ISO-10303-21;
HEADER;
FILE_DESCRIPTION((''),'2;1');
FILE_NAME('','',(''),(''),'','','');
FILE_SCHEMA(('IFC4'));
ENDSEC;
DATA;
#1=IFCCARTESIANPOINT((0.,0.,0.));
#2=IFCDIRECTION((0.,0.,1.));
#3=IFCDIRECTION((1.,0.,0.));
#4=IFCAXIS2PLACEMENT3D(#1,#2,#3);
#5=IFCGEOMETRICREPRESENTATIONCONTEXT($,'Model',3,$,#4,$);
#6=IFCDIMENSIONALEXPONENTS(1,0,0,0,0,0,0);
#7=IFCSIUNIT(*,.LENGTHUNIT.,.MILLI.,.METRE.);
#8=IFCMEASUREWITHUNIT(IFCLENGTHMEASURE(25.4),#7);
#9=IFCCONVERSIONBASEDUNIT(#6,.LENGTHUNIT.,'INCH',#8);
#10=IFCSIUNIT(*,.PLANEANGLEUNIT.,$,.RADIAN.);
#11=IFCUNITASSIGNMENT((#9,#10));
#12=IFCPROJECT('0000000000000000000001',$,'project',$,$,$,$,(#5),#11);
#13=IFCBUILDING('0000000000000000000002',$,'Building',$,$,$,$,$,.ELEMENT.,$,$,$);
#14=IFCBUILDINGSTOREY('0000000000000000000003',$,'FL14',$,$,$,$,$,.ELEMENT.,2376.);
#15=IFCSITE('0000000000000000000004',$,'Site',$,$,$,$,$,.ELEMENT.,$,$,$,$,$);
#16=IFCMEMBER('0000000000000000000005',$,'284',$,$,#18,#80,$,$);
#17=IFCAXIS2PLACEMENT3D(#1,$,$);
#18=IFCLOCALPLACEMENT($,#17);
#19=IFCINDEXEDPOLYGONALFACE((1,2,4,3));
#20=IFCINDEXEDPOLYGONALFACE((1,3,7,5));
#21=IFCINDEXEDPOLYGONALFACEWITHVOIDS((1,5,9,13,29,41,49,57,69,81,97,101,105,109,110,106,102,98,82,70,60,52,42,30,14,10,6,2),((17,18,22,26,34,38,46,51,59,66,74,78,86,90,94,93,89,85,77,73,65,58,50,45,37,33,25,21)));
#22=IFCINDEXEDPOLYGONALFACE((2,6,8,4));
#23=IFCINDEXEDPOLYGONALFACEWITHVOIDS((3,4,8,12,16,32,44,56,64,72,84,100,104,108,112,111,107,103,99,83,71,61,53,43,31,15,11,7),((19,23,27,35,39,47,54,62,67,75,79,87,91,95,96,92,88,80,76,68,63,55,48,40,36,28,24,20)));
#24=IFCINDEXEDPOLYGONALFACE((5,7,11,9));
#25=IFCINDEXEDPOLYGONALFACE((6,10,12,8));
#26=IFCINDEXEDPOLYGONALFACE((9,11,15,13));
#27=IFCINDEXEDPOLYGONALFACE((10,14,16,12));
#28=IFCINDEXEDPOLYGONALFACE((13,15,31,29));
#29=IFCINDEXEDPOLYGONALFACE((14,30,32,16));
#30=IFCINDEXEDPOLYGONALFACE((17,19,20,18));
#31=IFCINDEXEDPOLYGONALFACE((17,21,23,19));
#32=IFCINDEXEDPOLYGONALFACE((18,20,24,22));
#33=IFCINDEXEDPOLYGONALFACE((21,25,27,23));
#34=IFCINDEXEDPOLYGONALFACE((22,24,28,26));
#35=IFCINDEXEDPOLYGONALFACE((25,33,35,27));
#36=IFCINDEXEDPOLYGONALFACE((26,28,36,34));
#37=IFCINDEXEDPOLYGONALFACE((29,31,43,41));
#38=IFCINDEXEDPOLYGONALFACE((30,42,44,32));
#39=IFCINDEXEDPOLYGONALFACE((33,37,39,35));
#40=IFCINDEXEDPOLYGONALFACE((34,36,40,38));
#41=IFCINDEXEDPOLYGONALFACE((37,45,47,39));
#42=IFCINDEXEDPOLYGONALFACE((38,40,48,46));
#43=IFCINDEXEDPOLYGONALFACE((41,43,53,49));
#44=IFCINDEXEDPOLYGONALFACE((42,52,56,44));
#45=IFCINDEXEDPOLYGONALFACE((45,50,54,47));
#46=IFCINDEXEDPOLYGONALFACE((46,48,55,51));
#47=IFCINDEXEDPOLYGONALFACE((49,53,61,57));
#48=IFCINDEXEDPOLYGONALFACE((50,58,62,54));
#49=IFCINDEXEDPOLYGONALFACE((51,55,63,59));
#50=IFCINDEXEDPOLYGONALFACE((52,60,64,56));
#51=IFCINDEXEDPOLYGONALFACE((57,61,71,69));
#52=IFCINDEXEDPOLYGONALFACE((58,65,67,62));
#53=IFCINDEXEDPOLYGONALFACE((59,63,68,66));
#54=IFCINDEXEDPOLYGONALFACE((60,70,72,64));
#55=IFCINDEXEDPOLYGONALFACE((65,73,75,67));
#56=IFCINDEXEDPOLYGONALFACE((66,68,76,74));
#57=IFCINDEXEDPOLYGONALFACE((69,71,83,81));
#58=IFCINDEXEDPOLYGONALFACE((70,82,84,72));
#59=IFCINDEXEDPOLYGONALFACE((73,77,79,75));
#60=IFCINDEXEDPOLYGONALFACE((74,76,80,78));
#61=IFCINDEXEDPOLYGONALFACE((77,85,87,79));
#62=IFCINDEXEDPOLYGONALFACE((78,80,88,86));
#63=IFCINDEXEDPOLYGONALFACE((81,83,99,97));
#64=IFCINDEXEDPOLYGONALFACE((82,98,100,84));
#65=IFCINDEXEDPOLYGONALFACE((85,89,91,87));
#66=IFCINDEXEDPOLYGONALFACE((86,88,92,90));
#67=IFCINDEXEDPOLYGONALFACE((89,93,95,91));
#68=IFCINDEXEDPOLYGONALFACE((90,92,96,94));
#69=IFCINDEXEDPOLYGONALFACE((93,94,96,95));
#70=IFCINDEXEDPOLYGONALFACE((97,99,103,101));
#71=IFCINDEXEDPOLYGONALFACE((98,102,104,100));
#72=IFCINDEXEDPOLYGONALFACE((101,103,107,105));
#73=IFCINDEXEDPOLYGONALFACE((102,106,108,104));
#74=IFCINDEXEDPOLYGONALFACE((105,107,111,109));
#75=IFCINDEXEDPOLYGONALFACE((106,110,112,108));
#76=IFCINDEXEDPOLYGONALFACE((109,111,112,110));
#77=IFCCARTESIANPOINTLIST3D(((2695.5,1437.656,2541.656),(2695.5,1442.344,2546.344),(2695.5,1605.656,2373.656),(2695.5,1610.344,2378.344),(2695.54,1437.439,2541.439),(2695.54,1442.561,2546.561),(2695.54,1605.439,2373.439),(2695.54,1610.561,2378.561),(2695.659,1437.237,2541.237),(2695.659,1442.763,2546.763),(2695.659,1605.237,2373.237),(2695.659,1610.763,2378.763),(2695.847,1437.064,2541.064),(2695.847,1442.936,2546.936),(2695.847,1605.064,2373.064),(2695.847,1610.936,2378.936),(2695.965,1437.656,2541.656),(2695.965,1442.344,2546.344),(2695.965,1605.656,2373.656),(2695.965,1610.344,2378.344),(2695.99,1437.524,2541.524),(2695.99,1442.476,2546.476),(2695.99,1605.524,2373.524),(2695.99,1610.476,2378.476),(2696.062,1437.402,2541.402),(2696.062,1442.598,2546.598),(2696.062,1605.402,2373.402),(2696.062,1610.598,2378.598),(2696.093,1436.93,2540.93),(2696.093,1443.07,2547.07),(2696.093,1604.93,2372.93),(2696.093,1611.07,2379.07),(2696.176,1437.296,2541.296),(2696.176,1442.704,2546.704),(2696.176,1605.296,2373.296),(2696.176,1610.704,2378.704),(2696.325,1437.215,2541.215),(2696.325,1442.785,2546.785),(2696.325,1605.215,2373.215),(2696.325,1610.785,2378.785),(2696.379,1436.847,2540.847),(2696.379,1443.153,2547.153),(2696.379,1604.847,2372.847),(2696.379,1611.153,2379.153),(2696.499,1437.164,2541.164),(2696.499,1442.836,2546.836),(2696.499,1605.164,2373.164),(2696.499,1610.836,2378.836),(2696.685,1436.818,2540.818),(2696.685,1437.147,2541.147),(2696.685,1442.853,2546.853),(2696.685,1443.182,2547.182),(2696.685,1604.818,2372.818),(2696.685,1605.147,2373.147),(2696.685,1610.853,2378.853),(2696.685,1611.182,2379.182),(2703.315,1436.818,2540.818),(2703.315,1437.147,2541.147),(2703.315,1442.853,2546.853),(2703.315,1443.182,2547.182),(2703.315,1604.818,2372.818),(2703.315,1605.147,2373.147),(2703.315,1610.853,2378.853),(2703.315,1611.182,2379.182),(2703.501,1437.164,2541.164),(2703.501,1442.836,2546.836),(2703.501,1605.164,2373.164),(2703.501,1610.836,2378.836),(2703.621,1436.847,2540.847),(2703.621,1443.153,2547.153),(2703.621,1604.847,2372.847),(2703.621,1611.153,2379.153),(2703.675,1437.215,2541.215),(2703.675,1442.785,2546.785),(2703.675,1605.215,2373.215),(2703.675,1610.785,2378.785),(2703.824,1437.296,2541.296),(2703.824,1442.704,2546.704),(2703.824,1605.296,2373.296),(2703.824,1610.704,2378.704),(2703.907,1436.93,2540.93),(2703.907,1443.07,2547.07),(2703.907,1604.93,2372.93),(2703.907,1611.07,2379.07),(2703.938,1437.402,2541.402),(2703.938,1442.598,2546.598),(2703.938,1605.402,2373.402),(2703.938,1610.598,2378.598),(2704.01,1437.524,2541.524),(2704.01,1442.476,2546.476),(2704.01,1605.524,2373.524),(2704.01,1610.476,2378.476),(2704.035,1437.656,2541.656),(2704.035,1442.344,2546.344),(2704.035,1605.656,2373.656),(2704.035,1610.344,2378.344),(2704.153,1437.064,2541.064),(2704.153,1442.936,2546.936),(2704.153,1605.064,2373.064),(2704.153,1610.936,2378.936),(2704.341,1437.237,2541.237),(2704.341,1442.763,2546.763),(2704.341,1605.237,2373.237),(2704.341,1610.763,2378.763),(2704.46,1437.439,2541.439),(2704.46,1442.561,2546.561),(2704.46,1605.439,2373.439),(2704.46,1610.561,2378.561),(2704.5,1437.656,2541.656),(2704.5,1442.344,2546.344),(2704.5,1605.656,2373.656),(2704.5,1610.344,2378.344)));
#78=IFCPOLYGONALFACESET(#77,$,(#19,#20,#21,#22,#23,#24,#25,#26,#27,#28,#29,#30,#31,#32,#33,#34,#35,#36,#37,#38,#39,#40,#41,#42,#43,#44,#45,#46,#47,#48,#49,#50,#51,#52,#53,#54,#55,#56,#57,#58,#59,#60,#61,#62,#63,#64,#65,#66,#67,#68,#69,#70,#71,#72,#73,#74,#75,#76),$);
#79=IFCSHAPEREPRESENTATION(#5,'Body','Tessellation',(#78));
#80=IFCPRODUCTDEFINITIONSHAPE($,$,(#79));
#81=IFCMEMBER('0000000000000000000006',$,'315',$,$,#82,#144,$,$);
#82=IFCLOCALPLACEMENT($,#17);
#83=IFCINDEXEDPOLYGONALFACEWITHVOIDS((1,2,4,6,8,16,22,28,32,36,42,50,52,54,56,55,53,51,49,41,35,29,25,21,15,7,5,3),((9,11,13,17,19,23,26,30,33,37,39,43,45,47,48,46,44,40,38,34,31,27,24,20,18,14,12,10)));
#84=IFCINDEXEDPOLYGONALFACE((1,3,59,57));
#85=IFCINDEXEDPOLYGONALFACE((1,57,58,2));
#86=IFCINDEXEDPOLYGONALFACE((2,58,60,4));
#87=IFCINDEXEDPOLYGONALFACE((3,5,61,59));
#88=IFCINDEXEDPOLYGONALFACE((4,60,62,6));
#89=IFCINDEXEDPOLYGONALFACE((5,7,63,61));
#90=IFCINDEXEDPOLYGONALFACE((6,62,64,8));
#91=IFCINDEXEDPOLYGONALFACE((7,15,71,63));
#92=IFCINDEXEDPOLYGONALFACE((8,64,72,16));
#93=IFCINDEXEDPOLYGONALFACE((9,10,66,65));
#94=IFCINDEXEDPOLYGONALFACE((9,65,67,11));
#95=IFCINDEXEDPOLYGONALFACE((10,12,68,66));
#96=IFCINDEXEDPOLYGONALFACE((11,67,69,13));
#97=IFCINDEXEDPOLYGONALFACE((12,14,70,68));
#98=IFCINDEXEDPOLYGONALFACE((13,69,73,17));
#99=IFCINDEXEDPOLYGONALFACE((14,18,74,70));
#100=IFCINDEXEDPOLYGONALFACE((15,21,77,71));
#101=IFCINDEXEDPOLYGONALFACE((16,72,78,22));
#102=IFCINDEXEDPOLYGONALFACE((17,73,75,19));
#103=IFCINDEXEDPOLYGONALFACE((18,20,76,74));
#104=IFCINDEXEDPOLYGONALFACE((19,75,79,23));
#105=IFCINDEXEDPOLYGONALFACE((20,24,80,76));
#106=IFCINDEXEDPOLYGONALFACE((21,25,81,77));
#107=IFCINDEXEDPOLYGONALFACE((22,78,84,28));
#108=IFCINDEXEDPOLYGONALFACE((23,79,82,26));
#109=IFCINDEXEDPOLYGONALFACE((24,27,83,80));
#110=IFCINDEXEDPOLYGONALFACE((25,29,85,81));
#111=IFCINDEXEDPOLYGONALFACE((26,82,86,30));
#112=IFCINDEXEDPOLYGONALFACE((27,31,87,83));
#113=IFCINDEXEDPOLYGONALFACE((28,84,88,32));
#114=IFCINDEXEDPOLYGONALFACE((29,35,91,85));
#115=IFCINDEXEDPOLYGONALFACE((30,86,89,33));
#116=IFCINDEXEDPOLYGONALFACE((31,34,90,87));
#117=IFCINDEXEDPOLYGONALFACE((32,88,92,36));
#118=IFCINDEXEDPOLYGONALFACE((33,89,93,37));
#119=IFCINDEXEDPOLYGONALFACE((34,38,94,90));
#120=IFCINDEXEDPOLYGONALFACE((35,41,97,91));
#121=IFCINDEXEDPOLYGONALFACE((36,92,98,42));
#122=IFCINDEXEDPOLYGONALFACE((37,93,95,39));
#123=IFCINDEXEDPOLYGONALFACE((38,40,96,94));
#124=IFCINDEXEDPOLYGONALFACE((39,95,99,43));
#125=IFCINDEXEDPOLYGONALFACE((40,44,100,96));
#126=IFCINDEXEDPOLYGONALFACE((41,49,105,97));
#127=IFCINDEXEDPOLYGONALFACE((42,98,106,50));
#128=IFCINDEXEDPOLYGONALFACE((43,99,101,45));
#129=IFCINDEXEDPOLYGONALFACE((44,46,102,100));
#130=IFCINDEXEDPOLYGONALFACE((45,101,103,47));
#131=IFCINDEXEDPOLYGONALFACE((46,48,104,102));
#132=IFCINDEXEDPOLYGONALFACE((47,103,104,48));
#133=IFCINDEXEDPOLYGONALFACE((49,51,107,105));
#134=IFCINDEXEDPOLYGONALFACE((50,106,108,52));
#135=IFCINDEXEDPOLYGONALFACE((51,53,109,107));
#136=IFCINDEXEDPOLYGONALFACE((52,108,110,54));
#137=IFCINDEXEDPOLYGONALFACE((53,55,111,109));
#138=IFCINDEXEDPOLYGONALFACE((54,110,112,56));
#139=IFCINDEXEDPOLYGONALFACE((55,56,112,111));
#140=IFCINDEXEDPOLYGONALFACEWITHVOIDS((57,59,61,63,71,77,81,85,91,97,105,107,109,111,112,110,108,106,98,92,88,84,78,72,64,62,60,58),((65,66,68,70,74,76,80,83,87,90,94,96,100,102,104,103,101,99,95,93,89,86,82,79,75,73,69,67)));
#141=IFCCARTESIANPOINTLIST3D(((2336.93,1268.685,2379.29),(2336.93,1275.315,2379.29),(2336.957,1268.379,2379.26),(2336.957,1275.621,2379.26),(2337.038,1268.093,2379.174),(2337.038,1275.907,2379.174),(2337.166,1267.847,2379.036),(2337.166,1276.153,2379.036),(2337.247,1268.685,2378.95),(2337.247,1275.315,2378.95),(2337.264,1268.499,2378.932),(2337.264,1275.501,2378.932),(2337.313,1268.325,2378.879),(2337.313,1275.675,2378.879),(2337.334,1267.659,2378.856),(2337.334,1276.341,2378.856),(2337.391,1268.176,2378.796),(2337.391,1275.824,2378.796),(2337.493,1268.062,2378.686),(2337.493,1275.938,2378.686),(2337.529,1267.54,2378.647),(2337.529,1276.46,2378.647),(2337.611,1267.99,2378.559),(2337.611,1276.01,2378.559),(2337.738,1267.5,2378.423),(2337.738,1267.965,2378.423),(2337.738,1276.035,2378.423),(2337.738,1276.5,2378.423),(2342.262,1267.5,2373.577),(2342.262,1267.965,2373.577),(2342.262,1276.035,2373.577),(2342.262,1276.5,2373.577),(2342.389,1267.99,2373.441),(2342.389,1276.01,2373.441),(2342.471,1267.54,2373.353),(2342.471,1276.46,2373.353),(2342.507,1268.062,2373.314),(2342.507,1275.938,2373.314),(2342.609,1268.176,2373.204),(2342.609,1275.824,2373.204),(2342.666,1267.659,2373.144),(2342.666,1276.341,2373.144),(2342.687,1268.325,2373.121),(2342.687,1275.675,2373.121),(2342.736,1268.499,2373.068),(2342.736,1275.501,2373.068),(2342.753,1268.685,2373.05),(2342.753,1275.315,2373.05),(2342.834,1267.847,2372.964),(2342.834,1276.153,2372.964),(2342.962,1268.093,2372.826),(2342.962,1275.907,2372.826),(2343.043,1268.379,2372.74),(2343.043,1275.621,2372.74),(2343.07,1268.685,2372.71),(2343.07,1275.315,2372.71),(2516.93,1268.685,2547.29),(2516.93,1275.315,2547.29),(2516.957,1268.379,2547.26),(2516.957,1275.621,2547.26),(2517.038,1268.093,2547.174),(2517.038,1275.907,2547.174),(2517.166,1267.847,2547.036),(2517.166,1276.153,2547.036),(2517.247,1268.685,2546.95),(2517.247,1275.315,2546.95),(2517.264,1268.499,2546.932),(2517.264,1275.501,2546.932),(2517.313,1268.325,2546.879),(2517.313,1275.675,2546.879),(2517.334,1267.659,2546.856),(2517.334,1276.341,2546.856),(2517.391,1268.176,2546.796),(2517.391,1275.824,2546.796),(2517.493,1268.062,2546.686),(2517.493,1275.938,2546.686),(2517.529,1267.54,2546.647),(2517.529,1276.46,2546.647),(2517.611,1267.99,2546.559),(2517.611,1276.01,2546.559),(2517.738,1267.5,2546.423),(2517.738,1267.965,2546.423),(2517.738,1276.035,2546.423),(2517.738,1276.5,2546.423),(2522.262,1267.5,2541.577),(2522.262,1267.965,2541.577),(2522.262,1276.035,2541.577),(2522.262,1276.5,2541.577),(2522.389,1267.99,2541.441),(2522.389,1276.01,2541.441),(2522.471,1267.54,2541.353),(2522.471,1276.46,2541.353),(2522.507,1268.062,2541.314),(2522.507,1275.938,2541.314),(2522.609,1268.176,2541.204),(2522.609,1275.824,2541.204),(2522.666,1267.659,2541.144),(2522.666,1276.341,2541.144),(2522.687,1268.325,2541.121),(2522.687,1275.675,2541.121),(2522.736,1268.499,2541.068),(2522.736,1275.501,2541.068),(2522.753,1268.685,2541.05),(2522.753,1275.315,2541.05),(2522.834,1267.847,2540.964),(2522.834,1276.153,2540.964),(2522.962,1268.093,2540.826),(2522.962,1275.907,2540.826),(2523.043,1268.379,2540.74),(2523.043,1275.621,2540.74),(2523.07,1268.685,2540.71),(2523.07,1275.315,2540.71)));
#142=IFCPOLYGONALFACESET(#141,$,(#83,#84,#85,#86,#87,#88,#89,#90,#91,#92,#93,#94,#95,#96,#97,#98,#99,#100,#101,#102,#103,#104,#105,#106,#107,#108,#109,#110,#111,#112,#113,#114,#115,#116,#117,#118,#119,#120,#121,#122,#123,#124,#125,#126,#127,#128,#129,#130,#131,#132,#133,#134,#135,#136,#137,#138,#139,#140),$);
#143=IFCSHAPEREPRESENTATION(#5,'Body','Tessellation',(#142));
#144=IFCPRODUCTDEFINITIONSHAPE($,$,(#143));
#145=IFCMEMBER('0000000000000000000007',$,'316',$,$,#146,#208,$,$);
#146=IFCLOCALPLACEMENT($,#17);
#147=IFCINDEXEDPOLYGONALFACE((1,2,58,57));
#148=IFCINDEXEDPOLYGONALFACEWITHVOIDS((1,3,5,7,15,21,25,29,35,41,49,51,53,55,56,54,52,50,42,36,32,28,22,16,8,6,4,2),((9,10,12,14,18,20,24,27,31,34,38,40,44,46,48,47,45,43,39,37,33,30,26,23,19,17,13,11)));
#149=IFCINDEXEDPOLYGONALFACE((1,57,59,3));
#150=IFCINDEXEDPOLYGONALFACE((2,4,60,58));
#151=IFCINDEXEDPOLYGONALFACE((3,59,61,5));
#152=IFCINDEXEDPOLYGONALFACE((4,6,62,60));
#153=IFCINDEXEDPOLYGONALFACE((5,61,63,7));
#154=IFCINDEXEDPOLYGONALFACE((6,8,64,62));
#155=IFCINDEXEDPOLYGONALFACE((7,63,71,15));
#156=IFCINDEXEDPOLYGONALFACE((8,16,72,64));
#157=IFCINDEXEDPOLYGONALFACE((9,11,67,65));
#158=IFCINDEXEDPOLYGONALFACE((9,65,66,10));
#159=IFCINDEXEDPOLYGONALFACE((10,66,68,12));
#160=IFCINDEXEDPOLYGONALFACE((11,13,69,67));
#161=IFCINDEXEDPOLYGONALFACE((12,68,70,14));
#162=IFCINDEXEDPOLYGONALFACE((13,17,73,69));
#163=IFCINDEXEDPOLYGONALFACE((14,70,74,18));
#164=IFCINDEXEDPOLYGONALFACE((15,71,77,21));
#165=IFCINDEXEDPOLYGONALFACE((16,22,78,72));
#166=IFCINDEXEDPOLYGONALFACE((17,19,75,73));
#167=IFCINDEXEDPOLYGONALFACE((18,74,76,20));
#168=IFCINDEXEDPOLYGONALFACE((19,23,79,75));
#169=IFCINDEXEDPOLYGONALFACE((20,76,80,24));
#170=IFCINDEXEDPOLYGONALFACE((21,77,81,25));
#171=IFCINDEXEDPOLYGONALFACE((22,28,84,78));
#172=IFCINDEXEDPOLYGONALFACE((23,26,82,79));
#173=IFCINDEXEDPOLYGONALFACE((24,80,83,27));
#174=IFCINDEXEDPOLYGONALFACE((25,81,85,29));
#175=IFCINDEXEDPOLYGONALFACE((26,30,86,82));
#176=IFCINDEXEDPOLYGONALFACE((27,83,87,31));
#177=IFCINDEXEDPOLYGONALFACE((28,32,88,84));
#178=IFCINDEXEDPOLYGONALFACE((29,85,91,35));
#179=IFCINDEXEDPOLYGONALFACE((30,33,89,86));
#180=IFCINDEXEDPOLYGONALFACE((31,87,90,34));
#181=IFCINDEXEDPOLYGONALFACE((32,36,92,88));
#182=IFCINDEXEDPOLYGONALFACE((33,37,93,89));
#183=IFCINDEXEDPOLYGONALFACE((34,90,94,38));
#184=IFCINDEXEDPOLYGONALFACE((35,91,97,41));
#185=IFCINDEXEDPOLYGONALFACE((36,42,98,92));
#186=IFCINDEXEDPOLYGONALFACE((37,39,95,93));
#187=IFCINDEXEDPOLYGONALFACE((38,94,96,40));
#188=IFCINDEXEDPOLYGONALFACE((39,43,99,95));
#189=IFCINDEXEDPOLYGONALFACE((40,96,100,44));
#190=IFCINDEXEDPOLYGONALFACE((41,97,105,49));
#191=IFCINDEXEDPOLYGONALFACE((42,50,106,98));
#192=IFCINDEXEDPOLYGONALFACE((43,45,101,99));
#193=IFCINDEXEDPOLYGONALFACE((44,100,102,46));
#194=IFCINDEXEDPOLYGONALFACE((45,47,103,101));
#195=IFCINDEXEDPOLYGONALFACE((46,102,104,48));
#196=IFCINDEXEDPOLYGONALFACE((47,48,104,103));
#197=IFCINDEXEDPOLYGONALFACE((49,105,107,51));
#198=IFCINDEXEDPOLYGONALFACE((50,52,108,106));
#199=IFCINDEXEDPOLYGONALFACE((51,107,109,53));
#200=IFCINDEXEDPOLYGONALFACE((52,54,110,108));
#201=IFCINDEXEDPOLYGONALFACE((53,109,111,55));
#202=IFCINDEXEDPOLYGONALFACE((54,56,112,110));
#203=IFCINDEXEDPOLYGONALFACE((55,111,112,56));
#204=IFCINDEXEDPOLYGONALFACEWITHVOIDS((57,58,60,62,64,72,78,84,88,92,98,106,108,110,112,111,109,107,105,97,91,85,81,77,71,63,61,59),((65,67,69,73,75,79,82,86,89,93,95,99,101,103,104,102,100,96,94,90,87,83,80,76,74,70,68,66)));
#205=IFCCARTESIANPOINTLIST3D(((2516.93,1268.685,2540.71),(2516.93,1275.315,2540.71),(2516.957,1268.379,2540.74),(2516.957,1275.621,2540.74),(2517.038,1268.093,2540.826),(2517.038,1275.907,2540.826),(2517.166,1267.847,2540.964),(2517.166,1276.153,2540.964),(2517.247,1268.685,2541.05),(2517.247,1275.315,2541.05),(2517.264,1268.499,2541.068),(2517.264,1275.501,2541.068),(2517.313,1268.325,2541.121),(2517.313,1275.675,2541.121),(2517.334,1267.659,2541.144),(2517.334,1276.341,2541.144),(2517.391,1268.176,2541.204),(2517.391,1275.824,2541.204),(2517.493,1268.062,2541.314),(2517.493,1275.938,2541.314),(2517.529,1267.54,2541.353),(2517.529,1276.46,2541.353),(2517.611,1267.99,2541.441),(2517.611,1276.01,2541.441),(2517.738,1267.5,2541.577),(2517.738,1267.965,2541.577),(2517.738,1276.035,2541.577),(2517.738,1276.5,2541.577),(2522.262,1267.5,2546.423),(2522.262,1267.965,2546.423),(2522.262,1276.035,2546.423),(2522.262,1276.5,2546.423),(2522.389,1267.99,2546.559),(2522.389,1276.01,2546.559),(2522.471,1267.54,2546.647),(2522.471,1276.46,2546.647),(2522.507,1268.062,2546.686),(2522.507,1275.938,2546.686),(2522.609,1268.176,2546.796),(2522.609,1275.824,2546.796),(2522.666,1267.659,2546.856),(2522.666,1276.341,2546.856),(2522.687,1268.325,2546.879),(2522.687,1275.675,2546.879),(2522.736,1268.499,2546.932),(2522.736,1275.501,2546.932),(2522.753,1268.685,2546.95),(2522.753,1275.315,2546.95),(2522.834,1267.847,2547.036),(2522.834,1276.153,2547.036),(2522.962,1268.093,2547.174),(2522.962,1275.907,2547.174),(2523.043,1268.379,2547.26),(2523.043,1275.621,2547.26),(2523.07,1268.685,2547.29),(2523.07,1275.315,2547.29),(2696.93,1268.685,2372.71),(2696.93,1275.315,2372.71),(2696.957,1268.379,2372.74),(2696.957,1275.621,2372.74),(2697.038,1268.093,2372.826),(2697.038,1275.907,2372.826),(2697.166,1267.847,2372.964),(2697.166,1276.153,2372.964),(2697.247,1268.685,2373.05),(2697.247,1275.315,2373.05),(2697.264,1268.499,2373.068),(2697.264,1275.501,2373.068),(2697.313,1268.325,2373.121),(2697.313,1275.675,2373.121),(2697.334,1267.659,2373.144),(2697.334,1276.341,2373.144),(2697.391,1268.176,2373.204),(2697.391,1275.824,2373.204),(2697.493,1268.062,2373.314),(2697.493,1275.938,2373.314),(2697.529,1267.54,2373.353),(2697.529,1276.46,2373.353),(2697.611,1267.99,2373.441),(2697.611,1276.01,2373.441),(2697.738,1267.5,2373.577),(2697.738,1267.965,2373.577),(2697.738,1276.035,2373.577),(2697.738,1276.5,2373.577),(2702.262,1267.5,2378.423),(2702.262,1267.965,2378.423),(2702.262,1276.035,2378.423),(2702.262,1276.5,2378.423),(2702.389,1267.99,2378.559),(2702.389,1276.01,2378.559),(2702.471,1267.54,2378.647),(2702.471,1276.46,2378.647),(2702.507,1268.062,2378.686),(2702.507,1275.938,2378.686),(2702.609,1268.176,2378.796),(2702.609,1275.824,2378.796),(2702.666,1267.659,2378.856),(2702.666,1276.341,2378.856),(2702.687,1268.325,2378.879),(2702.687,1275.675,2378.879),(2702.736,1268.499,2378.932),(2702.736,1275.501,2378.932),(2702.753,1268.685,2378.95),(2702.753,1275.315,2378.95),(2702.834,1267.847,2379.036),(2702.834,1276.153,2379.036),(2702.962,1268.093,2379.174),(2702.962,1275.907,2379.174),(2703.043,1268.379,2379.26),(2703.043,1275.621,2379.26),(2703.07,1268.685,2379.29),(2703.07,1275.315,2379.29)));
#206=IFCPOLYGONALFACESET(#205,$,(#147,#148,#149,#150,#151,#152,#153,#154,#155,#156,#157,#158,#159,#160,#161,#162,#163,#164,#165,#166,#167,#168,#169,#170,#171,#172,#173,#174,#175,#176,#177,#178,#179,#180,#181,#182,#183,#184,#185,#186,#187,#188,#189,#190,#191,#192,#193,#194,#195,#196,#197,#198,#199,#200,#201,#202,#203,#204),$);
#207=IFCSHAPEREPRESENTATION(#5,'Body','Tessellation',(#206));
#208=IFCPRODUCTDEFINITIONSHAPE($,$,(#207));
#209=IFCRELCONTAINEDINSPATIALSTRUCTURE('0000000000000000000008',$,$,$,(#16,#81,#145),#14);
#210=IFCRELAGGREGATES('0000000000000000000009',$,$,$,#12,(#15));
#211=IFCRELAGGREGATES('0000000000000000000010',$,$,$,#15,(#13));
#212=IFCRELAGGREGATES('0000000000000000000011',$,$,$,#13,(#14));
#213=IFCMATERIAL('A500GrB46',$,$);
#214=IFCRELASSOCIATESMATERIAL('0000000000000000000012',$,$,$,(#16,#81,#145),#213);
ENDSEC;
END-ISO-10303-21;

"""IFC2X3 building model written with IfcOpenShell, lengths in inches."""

from ifc_helpers import new_model, entity, si_unit, converted_unit, frame, origin_with_axes, origin_2d_with_axis, place, context, project, spatial, hollow_rectangle, extrude, material, element, save


model = new_model("IFC2X3")

# Units and contexts
model_context = context("Model", 3, world=origin_with_axes())
ifc_project = project(units=[converted_unit("LENGTHUNIT", "INCH", entity("IfcLengthMeasure", 25.4), si_unit("LENGTHUNIT", "METRE", prefix="MILLI"), dimensions=[1, 0, 0, 0, 0, 0, 0]), si_unit("PLANEANGLEUNIT", "RADIAN")], contexts=[model_context])

# Site, building, storey
site = spatial("IfcSite", under=ifc_project, Name="Site", CompositionType="ELEMENT")
building = spatial("IfcBuilding", under=site, Name="Building", CompositionType="ELEMENT")
storey = spatial("IfcBuildingStorey", under=building, Name="FL14", CompositionType="ELEMENT", Elevation=2376.0)

# Members
ifc_material_1 = material(Name="A500GrB46")
for number, where, z_axis, x_axis, name in (
    (1, (2700.0, 1608.0, 2376.0), (0.0, -0.707107, 0.707107), (1.0, 0.0, 0.0), "284"),
):
    element("IfcMember", number, at=place(None, frame(where, z_axis=z_axis, x_axis=x_axis)), inside=storey, material=ifc_material_1, Name=name, context=model_context, shape_type="SweptSolid", body=[
        extrude(hollow_rectangle(XDim=9.0, YDim=9.0, WallThickness=0.465, InnerFilletRadius=0.72, OuterFilletRadius=1.185, at=origin_2d_with_axis()), origin_with_axes(), (0.0, 0.0, 1.0), 237.588),
    ])
for number, where, z_axis, x_axis, name in (
    (2, (2340.0, 1272.0, 2376.0), (0.731055, 0.0, 0.682318), (0.0, 1.0, 0.0), "315"),
    (3, (2700.0, 1272.0, 2376.0), (-0.731055, 0.0, 0.682318), (0.0, -1.0, 0.0), "316"),
):
    element("IfcMember", number, at=place(None, frame(where, z_axis=z_axis, x_axis=x_axis)), inside=storey, material=ifc_material_1, Name=name, context=model_context, shape_type="SweptSolid", body=[
        extrude(hollow_rectangle(XDim=9.0, YDim=9.0, WallThickness=0.465, InnerFilletRadius=0.72, OuterFilletRadius=1.185, at=origin_2d_with_axis()), origin_with_axes(), (0.0, 0.0, 1.0), 246.219),
    ])

save(model, "model.ifc")
